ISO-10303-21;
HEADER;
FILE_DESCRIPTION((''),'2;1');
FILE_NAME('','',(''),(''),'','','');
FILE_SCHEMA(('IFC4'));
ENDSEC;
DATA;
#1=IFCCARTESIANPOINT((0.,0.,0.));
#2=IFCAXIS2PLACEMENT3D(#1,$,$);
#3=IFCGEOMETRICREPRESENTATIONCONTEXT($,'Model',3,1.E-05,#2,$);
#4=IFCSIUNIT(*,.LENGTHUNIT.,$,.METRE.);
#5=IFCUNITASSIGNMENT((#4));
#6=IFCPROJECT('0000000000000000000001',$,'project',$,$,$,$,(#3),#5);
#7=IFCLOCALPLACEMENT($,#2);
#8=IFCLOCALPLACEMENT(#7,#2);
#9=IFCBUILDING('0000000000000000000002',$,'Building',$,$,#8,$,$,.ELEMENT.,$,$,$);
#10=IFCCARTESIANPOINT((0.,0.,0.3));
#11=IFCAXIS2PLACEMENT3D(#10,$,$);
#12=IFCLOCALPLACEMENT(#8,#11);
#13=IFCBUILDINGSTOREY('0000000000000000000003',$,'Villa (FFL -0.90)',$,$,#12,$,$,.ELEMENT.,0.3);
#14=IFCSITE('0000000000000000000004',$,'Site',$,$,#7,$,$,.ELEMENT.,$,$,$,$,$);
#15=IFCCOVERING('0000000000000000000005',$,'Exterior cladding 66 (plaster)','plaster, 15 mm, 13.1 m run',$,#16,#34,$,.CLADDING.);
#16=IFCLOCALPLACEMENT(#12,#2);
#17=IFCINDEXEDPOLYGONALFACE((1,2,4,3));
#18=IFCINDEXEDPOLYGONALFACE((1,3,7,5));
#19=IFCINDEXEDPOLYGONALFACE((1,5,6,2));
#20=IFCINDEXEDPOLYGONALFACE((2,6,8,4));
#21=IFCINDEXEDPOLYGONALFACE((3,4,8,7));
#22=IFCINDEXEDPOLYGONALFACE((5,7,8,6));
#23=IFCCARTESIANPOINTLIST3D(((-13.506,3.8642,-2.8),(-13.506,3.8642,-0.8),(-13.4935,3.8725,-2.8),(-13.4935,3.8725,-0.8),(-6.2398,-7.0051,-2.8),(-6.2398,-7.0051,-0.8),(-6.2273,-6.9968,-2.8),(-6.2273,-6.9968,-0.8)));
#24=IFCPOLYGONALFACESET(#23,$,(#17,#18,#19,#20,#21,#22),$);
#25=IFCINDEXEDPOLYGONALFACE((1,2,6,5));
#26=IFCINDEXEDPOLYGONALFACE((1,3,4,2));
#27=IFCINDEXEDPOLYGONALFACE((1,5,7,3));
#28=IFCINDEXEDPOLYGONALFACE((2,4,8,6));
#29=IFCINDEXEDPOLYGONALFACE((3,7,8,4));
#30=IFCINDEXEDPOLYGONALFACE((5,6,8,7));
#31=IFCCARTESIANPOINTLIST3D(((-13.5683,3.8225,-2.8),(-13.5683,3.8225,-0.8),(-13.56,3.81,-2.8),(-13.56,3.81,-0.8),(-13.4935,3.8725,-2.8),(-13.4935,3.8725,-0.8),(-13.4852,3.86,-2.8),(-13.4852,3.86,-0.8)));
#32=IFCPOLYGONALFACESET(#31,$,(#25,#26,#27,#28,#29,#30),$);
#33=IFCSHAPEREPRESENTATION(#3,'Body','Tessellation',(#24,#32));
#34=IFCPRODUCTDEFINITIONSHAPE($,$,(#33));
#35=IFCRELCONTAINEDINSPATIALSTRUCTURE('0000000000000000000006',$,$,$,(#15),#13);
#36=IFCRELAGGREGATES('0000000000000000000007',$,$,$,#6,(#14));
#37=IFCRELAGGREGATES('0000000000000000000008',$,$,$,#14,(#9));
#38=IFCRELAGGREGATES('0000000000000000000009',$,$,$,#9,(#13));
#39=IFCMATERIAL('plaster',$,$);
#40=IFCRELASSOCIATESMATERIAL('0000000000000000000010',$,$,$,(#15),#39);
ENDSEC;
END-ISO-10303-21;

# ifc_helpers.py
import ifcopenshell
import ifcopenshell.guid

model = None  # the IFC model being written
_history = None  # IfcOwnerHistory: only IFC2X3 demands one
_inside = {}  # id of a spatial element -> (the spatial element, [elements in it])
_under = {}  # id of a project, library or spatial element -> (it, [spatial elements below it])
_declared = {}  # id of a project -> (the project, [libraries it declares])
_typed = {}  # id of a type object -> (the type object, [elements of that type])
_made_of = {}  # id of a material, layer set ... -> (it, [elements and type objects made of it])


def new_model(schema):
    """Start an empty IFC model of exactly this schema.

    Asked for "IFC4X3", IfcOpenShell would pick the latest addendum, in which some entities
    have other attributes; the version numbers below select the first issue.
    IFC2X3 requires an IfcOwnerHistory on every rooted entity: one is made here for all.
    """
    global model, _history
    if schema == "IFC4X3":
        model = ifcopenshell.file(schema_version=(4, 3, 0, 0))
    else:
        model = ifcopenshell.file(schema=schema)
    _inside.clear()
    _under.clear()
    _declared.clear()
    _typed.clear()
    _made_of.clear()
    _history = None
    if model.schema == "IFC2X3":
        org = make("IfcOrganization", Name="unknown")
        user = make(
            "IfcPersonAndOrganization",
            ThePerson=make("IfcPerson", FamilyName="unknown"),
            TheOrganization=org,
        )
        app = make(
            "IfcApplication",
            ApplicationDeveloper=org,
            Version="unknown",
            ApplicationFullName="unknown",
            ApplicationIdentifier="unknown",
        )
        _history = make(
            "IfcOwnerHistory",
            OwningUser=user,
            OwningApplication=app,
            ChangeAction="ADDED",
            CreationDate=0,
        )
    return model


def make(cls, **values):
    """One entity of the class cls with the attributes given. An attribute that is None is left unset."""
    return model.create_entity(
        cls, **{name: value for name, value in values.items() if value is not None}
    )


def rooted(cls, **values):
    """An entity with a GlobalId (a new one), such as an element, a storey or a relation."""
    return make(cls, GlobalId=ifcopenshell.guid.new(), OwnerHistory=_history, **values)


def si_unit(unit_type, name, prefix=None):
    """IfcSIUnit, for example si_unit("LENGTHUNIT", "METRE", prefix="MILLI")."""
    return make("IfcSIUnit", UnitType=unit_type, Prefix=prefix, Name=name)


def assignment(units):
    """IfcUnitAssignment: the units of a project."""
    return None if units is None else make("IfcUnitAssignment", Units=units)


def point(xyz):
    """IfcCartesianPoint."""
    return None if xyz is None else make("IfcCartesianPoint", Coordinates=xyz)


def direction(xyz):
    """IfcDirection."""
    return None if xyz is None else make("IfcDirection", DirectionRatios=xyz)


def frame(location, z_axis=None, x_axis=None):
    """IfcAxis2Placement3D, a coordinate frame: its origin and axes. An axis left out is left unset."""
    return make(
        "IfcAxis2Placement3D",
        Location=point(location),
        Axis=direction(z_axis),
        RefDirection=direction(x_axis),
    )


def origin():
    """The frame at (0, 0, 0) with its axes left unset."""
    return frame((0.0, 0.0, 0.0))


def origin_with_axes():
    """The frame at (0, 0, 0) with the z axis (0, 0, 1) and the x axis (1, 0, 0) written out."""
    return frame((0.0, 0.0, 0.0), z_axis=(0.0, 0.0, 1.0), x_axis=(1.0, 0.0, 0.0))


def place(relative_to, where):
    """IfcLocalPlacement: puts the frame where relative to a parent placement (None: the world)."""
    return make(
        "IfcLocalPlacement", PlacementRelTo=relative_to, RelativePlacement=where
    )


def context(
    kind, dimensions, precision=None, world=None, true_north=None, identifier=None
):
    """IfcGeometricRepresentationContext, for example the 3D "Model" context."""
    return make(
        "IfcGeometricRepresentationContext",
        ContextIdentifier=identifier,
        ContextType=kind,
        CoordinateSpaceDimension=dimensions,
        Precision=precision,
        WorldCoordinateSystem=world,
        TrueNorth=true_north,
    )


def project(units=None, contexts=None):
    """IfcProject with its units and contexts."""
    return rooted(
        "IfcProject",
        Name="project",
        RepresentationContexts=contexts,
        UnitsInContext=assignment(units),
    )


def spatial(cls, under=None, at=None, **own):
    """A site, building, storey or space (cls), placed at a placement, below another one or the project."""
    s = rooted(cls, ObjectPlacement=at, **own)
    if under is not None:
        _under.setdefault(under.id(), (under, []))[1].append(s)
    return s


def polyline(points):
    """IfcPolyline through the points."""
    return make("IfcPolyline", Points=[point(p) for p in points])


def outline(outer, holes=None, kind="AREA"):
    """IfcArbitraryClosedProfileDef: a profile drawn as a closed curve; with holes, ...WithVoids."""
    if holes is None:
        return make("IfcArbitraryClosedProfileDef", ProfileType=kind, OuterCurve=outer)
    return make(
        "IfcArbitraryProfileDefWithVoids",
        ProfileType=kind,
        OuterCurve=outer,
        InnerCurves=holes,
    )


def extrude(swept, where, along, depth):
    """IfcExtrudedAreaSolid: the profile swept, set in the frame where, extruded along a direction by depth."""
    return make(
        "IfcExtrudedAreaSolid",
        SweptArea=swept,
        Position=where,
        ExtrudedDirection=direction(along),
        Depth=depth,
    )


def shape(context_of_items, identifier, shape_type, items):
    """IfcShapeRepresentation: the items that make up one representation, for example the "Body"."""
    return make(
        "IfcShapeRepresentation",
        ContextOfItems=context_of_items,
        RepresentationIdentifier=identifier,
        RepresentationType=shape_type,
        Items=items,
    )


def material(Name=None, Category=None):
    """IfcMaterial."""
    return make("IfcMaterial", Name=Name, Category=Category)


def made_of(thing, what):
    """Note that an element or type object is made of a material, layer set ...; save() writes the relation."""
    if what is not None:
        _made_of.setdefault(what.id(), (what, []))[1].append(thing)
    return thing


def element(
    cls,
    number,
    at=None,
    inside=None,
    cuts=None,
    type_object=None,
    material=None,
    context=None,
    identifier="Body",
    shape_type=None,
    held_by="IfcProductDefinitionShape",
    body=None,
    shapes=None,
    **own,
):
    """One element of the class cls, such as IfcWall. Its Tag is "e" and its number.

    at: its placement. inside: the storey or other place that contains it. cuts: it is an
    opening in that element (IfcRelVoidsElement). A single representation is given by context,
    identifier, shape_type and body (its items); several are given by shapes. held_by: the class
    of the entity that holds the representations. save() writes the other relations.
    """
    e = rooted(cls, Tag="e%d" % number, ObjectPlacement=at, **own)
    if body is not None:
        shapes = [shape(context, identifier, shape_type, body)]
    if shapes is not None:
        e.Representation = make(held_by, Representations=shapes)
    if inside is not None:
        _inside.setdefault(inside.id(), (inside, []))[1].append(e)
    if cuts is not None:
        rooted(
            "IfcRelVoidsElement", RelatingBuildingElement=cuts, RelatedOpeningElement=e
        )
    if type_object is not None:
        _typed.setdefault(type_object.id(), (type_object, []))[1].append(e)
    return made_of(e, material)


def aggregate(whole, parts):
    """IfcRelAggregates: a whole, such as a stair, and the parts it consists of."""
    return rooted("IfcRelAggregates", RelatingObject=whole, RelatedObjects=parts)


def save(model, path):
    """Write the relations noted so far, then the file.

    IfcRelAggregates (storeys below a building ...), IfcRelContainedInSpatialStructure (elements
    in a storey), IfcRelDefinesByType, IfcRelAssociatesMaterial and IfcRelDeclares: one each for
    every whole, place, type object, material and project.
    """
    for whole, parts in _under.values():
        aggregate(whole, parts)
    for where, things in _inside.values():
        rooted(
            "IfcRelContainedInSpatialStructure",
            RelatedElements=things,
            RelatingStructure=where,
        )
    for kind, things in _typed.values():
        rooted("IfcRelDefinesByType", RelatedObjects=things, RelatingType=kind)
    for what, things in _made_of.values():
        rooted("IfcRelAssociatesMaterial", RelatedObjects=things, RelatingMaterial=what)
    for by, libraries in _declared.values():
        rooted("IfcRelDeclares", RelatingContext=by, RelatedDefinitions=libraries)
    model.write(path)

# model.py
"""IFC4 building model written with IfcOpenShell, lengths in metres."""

from ifc_helpers import new_model, si_unit, frame, origin, origin_with_axes, place, context, project, spatial, polyline, outline, extrude, material, element, save


model = new_model("IFC4")

# Units and contexts
model_context = context("Model", 3, precision=1e-05, world=origin())
ifc_project = project(units=[si_unit("LENGTHUNIT", "METRE")], contexts=[model_context])

# Site, building, storey
site_placement = place(None, origin())
site = spatial("IfcSite", under=ifc_project, at=site_placement, Name="Site", CompositionType="ELEMENT")
building_placement = place(site_placement, origin())
building = spatial("IfcBuilding", under=site, at=building_placement, Name="Building", CompositionType="ELEMENT")
storey_placement = place(building_placement, frame((0.0, 0.0, 0.3)))
storey = spatial("IfcBuildingStorey", under=building, at=storey_placement, Name="Villa (FFL -0.90)", CompositionType="ELEMENT", Elevation=0.3)

# Covering
ifc_material = material(Name="plaster")
covering_1_placement = place(storey_placement, origin_with_axes())
element("IfcCovering", 1, at=covering_1_placement, inside=storey, material=ifc_material, Name="Exterior cladding 66 (plaster)", Description="plaster, 15 mm, 13.1 m run", PredefinedType="CLADDING", context=model_context, shape_type="SweptSolid", body=[
    extrude(outline(polyline([(-6.2273, -6.9968), (-13.4935, 3.8725), (-13.506, 3.8641), (-6.2398, -7.0051), (-6.2273, -6.9968)])), frame((0.0, 0.0, -2.8)), (0.0, 0.0, 1.0), 2.0),
    extrude(outline(polyline([(-13.4935, 3.8725), (-13.5683, 3.8225), (-13.56, 3.81), (-13.4852, 3.86), (-13.4935, 3.8725)])), frame((0.0, 0.0, -2.8)), (0.0, 0.0, 1.0), 2.0),
])

save(model, "model.ifc")
